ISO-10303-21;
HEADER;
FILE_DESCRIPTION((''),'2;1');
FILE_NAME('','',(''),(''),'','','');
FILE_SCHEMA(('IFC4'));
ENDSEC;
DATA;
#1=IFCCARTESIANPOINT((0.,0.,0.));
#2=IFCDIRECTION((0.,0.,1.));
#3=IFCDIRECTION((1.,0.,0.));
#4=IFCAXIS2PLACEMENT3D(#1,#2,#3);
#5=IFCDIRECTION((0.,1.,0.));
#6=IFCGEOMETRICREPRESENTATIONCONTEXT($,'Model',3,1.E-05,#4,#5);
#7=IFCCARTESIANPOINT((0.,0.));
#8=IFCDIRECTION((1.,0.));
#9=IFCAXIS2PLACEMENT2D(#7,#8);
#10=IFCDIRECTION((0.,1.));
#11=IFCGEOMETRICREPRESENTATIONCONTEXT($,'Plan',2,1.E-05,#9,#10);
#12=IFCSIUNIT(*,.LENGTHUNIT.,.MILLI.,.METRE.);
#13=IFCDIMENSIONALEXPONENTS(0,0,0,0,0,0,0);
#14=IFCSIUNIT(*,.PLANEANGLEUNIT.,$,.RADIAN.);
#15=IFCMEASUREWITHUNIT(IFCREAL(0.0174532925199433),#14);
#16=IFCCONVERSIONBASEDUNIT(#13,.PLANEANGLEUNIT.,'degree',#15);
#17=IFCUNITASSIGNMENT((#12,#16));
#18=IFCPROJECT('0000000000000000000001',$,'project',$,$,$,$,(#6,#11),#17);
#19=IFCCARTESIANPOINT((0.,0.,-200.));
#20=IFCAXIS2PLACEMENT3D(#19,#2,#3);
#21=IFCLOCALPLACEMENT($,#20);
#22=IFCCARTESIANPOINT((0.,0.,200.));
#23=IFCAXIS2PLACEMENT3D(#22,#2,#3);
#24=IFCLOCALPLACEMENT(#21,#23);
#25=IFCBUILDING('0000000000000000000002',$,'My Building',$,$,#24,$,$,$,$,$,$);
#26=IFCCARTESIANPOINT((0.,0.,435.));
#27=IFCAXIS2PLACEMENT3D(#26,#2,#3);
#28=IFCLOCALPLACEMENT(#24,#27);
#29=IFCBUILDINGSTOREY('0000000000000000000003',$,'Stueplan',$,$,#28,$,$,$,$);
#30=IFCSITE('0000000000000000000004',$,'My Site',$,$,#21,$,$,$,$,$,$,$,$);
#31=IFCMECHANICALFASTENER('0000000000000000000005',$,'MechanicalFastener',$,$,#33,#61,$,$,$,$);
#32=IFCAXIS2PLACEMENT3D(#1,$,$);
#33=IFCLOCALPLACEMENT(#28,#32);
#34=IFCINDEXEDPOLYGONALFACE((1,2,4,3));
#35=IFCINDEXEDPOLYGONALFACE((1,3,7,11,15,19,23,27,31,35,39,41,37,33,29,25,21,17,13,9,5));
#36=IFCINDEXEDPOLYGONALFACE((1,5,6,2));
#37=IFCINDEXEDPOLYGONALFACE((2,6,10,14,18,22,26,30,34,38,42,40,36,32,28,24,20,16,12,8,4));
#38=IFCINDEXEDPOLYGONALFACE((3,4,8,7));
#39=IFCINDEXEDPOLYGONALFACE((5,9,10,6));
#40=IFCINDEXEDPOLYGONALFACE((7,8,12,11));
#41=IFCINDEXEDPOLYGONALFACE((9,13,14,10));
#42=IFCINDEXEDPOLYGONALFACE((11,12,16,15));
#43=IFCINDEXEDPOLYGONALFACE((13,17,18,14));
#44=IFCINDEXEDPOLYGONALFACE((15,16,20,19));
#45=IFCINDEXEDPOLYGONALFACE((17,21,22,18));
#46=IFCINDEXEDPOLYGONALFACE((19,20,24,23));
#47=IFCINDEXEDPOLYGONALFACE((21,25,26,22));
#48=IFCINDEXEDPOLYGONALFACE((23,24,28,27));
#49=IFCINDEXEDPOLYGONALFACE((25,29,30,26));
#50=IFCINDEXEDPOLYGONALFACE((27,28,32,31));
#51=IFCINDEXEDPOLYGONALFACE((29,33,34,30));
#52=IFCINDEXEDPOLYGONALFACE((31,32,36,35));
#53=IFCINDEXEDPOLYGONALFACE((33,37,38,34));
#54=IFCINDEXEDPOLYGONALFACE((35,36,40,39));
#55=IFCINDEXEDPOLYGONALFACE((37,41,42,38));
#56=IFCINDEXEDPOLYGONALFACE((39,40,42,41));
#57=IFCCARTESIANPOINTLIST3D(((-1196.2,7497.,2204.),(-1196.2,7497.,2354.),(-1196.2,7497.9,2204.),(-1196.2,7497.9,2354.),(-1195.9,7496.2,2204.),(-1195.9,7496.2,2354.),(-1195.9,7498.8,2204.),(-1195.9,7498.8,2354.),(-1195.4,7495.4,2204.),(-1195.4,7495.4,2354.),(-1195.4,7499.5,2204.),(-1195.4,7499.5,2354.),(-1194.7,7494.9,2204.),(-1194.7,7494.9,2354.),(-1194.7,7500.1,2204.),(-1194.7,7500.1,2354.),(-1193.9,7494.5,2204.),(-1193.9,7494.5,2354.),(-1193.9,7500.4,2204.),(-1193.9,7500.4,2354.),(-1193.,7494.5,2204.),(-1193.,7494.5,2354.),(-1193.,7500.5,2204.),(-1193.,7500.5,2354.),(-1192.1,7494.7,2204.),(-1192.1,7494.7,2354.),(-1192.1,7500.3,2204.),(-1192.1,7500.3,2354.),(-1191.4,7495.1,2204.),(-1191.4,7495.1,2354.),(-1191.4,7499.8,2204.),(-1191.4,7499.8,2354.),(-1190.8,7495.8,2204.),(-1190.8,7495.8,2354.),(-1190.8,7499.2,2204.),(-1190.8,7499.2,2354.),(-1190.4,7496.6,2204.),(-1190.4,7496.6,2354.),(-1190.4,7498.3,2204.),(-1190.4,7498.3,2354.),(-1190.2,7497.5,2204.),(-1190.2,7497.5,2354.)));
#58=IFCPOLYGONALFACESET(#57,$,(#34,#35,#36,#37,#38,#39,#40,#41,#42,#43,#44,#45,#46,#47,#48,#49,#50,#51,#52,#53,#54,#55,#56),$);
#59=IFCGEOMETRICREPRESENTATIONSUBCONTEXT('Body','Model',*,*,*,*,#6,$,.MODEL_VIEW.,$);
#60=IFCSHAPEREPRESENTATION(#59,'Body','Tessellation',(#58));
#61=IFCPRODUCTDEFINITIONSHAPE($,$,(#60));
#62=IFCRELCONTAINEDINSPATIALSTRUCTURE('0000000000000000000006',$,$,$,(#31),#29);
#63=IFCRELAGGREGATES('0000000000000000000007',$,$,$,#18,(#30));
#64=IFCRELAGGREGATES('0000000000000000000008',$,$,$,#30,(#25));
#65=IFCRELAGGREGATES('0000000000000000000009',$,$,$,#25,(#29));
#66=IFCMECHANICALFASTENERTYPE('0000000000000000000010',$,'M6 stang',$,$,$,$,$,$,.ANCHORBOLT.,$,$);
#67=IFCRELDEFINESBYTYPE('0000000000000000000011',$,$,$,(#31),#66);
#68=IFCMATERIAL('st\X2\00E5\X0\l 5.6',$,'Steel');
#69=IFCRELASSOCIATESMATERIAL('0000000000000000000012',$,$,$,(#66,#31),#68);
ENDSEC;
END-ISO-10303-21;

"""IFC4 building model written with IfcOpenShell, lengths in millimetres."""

from ifc_helpers import new_model, entity, si_unit, converted_unit, direction, frame, origin_with_axes, origin_2d_with_axis, place, context, subcontext, project, spatial, circle, extrude, material, material_profile, profile_set, profile_usage, type_object, element, save


model = new_model("IFC4")

# Units and contexts
model_context = context("Model", 3, precision=1e-05, world=origin_with_axes(), true_north=direction((0.0, 1.0, 0.0)))
plan_context = context("Plan", 2, precision=1e-05, world=origin_2d_with_axis(), true_north=direction((0.0, 1.0)))
body_context_1 = subcontext(model_context, "Body", "Model", "MODEL_VIEW")
ifc_project = project(units=[si_unit("LENGTHUNIT", "METRE", prefix="MILLI"), converted_unit("PLANEANGLEUNIT", "degree", entity("IfcReal", 0.0174532925199433), si_unit("PLANEANGLEUNIT", "RADIAN"), dimensions=[0, 0, 0, 0, 0, 0, 0])], contexts=[model_context, plan_context])

# Site, building, storey
site_placement = place(None, frame((0.0, 0.0, -200.0), z_axis=(0.0, 0.0, 1.0), x_axis=(1.0, 0.0, 0.0)))
site = spatial("IfcSite", under=ifc_project, at=site_placement, Name="My Site")
building_placement = place(site_placement, frame((0.0, 0.0, 200.0), z_axis=(0.0, 0.0, 1.0), x_axis=(1.0, 0.0, 0.0)))
building = spatial("IfcBuilding", under=site, at=building_placement, Name="My Building")
storey_placement = place(building_placement, frame((0.0, 0.0, 435.0), z_axis=(0.0, 0.0, 1.0), x_axis=(1.0, 0.0, 0.0)))
storey = spatial("IfcBuildingStorey", under=building, at=storey_placement, Name="Stueplan")

# Mechanical fastener
ifc_material_1 = material(Name="stål 5.6", Category="Steel")
ifc_material_profile_1 = material_profile(ifc_material_1, circle(Radius=3.0))
ifc_profile_set_1 = profile_set([ifc_material_profile_1], Name="steel")
mechanical_fastener_type_1 = type_object("IfcMechanicalFastenerType", Name="M6 stang", PredefinedType="ANCHORBOLT", material=ifc_profile_set_1)
ifc_profile_usage_1 = profile_usage(ifc_profile_set_1)
mechanical_fastener_1_placement = place(storey_placement, frame((-1193.2, 7497.5, 2204.0), z_axis=(0.0, 0.0, 1.0), x_axis=(1.0, 0.0, 0.0)))
element("IfcMechanicalFastener", 1, at=mechanical_fastener_1_placement, inside=storey, type_object=mechanical_fastener_type_1, material=ifc_profile_usage_1, Name="MechanicalFastener", context=body_context_1, shape_type="SweptSolid", body=[
    extrude(circle(Radius=3.0), origin_with_axes(), (0.0, 0.0, 1.0), 150.0),
])

save(model, "model.ifc")
